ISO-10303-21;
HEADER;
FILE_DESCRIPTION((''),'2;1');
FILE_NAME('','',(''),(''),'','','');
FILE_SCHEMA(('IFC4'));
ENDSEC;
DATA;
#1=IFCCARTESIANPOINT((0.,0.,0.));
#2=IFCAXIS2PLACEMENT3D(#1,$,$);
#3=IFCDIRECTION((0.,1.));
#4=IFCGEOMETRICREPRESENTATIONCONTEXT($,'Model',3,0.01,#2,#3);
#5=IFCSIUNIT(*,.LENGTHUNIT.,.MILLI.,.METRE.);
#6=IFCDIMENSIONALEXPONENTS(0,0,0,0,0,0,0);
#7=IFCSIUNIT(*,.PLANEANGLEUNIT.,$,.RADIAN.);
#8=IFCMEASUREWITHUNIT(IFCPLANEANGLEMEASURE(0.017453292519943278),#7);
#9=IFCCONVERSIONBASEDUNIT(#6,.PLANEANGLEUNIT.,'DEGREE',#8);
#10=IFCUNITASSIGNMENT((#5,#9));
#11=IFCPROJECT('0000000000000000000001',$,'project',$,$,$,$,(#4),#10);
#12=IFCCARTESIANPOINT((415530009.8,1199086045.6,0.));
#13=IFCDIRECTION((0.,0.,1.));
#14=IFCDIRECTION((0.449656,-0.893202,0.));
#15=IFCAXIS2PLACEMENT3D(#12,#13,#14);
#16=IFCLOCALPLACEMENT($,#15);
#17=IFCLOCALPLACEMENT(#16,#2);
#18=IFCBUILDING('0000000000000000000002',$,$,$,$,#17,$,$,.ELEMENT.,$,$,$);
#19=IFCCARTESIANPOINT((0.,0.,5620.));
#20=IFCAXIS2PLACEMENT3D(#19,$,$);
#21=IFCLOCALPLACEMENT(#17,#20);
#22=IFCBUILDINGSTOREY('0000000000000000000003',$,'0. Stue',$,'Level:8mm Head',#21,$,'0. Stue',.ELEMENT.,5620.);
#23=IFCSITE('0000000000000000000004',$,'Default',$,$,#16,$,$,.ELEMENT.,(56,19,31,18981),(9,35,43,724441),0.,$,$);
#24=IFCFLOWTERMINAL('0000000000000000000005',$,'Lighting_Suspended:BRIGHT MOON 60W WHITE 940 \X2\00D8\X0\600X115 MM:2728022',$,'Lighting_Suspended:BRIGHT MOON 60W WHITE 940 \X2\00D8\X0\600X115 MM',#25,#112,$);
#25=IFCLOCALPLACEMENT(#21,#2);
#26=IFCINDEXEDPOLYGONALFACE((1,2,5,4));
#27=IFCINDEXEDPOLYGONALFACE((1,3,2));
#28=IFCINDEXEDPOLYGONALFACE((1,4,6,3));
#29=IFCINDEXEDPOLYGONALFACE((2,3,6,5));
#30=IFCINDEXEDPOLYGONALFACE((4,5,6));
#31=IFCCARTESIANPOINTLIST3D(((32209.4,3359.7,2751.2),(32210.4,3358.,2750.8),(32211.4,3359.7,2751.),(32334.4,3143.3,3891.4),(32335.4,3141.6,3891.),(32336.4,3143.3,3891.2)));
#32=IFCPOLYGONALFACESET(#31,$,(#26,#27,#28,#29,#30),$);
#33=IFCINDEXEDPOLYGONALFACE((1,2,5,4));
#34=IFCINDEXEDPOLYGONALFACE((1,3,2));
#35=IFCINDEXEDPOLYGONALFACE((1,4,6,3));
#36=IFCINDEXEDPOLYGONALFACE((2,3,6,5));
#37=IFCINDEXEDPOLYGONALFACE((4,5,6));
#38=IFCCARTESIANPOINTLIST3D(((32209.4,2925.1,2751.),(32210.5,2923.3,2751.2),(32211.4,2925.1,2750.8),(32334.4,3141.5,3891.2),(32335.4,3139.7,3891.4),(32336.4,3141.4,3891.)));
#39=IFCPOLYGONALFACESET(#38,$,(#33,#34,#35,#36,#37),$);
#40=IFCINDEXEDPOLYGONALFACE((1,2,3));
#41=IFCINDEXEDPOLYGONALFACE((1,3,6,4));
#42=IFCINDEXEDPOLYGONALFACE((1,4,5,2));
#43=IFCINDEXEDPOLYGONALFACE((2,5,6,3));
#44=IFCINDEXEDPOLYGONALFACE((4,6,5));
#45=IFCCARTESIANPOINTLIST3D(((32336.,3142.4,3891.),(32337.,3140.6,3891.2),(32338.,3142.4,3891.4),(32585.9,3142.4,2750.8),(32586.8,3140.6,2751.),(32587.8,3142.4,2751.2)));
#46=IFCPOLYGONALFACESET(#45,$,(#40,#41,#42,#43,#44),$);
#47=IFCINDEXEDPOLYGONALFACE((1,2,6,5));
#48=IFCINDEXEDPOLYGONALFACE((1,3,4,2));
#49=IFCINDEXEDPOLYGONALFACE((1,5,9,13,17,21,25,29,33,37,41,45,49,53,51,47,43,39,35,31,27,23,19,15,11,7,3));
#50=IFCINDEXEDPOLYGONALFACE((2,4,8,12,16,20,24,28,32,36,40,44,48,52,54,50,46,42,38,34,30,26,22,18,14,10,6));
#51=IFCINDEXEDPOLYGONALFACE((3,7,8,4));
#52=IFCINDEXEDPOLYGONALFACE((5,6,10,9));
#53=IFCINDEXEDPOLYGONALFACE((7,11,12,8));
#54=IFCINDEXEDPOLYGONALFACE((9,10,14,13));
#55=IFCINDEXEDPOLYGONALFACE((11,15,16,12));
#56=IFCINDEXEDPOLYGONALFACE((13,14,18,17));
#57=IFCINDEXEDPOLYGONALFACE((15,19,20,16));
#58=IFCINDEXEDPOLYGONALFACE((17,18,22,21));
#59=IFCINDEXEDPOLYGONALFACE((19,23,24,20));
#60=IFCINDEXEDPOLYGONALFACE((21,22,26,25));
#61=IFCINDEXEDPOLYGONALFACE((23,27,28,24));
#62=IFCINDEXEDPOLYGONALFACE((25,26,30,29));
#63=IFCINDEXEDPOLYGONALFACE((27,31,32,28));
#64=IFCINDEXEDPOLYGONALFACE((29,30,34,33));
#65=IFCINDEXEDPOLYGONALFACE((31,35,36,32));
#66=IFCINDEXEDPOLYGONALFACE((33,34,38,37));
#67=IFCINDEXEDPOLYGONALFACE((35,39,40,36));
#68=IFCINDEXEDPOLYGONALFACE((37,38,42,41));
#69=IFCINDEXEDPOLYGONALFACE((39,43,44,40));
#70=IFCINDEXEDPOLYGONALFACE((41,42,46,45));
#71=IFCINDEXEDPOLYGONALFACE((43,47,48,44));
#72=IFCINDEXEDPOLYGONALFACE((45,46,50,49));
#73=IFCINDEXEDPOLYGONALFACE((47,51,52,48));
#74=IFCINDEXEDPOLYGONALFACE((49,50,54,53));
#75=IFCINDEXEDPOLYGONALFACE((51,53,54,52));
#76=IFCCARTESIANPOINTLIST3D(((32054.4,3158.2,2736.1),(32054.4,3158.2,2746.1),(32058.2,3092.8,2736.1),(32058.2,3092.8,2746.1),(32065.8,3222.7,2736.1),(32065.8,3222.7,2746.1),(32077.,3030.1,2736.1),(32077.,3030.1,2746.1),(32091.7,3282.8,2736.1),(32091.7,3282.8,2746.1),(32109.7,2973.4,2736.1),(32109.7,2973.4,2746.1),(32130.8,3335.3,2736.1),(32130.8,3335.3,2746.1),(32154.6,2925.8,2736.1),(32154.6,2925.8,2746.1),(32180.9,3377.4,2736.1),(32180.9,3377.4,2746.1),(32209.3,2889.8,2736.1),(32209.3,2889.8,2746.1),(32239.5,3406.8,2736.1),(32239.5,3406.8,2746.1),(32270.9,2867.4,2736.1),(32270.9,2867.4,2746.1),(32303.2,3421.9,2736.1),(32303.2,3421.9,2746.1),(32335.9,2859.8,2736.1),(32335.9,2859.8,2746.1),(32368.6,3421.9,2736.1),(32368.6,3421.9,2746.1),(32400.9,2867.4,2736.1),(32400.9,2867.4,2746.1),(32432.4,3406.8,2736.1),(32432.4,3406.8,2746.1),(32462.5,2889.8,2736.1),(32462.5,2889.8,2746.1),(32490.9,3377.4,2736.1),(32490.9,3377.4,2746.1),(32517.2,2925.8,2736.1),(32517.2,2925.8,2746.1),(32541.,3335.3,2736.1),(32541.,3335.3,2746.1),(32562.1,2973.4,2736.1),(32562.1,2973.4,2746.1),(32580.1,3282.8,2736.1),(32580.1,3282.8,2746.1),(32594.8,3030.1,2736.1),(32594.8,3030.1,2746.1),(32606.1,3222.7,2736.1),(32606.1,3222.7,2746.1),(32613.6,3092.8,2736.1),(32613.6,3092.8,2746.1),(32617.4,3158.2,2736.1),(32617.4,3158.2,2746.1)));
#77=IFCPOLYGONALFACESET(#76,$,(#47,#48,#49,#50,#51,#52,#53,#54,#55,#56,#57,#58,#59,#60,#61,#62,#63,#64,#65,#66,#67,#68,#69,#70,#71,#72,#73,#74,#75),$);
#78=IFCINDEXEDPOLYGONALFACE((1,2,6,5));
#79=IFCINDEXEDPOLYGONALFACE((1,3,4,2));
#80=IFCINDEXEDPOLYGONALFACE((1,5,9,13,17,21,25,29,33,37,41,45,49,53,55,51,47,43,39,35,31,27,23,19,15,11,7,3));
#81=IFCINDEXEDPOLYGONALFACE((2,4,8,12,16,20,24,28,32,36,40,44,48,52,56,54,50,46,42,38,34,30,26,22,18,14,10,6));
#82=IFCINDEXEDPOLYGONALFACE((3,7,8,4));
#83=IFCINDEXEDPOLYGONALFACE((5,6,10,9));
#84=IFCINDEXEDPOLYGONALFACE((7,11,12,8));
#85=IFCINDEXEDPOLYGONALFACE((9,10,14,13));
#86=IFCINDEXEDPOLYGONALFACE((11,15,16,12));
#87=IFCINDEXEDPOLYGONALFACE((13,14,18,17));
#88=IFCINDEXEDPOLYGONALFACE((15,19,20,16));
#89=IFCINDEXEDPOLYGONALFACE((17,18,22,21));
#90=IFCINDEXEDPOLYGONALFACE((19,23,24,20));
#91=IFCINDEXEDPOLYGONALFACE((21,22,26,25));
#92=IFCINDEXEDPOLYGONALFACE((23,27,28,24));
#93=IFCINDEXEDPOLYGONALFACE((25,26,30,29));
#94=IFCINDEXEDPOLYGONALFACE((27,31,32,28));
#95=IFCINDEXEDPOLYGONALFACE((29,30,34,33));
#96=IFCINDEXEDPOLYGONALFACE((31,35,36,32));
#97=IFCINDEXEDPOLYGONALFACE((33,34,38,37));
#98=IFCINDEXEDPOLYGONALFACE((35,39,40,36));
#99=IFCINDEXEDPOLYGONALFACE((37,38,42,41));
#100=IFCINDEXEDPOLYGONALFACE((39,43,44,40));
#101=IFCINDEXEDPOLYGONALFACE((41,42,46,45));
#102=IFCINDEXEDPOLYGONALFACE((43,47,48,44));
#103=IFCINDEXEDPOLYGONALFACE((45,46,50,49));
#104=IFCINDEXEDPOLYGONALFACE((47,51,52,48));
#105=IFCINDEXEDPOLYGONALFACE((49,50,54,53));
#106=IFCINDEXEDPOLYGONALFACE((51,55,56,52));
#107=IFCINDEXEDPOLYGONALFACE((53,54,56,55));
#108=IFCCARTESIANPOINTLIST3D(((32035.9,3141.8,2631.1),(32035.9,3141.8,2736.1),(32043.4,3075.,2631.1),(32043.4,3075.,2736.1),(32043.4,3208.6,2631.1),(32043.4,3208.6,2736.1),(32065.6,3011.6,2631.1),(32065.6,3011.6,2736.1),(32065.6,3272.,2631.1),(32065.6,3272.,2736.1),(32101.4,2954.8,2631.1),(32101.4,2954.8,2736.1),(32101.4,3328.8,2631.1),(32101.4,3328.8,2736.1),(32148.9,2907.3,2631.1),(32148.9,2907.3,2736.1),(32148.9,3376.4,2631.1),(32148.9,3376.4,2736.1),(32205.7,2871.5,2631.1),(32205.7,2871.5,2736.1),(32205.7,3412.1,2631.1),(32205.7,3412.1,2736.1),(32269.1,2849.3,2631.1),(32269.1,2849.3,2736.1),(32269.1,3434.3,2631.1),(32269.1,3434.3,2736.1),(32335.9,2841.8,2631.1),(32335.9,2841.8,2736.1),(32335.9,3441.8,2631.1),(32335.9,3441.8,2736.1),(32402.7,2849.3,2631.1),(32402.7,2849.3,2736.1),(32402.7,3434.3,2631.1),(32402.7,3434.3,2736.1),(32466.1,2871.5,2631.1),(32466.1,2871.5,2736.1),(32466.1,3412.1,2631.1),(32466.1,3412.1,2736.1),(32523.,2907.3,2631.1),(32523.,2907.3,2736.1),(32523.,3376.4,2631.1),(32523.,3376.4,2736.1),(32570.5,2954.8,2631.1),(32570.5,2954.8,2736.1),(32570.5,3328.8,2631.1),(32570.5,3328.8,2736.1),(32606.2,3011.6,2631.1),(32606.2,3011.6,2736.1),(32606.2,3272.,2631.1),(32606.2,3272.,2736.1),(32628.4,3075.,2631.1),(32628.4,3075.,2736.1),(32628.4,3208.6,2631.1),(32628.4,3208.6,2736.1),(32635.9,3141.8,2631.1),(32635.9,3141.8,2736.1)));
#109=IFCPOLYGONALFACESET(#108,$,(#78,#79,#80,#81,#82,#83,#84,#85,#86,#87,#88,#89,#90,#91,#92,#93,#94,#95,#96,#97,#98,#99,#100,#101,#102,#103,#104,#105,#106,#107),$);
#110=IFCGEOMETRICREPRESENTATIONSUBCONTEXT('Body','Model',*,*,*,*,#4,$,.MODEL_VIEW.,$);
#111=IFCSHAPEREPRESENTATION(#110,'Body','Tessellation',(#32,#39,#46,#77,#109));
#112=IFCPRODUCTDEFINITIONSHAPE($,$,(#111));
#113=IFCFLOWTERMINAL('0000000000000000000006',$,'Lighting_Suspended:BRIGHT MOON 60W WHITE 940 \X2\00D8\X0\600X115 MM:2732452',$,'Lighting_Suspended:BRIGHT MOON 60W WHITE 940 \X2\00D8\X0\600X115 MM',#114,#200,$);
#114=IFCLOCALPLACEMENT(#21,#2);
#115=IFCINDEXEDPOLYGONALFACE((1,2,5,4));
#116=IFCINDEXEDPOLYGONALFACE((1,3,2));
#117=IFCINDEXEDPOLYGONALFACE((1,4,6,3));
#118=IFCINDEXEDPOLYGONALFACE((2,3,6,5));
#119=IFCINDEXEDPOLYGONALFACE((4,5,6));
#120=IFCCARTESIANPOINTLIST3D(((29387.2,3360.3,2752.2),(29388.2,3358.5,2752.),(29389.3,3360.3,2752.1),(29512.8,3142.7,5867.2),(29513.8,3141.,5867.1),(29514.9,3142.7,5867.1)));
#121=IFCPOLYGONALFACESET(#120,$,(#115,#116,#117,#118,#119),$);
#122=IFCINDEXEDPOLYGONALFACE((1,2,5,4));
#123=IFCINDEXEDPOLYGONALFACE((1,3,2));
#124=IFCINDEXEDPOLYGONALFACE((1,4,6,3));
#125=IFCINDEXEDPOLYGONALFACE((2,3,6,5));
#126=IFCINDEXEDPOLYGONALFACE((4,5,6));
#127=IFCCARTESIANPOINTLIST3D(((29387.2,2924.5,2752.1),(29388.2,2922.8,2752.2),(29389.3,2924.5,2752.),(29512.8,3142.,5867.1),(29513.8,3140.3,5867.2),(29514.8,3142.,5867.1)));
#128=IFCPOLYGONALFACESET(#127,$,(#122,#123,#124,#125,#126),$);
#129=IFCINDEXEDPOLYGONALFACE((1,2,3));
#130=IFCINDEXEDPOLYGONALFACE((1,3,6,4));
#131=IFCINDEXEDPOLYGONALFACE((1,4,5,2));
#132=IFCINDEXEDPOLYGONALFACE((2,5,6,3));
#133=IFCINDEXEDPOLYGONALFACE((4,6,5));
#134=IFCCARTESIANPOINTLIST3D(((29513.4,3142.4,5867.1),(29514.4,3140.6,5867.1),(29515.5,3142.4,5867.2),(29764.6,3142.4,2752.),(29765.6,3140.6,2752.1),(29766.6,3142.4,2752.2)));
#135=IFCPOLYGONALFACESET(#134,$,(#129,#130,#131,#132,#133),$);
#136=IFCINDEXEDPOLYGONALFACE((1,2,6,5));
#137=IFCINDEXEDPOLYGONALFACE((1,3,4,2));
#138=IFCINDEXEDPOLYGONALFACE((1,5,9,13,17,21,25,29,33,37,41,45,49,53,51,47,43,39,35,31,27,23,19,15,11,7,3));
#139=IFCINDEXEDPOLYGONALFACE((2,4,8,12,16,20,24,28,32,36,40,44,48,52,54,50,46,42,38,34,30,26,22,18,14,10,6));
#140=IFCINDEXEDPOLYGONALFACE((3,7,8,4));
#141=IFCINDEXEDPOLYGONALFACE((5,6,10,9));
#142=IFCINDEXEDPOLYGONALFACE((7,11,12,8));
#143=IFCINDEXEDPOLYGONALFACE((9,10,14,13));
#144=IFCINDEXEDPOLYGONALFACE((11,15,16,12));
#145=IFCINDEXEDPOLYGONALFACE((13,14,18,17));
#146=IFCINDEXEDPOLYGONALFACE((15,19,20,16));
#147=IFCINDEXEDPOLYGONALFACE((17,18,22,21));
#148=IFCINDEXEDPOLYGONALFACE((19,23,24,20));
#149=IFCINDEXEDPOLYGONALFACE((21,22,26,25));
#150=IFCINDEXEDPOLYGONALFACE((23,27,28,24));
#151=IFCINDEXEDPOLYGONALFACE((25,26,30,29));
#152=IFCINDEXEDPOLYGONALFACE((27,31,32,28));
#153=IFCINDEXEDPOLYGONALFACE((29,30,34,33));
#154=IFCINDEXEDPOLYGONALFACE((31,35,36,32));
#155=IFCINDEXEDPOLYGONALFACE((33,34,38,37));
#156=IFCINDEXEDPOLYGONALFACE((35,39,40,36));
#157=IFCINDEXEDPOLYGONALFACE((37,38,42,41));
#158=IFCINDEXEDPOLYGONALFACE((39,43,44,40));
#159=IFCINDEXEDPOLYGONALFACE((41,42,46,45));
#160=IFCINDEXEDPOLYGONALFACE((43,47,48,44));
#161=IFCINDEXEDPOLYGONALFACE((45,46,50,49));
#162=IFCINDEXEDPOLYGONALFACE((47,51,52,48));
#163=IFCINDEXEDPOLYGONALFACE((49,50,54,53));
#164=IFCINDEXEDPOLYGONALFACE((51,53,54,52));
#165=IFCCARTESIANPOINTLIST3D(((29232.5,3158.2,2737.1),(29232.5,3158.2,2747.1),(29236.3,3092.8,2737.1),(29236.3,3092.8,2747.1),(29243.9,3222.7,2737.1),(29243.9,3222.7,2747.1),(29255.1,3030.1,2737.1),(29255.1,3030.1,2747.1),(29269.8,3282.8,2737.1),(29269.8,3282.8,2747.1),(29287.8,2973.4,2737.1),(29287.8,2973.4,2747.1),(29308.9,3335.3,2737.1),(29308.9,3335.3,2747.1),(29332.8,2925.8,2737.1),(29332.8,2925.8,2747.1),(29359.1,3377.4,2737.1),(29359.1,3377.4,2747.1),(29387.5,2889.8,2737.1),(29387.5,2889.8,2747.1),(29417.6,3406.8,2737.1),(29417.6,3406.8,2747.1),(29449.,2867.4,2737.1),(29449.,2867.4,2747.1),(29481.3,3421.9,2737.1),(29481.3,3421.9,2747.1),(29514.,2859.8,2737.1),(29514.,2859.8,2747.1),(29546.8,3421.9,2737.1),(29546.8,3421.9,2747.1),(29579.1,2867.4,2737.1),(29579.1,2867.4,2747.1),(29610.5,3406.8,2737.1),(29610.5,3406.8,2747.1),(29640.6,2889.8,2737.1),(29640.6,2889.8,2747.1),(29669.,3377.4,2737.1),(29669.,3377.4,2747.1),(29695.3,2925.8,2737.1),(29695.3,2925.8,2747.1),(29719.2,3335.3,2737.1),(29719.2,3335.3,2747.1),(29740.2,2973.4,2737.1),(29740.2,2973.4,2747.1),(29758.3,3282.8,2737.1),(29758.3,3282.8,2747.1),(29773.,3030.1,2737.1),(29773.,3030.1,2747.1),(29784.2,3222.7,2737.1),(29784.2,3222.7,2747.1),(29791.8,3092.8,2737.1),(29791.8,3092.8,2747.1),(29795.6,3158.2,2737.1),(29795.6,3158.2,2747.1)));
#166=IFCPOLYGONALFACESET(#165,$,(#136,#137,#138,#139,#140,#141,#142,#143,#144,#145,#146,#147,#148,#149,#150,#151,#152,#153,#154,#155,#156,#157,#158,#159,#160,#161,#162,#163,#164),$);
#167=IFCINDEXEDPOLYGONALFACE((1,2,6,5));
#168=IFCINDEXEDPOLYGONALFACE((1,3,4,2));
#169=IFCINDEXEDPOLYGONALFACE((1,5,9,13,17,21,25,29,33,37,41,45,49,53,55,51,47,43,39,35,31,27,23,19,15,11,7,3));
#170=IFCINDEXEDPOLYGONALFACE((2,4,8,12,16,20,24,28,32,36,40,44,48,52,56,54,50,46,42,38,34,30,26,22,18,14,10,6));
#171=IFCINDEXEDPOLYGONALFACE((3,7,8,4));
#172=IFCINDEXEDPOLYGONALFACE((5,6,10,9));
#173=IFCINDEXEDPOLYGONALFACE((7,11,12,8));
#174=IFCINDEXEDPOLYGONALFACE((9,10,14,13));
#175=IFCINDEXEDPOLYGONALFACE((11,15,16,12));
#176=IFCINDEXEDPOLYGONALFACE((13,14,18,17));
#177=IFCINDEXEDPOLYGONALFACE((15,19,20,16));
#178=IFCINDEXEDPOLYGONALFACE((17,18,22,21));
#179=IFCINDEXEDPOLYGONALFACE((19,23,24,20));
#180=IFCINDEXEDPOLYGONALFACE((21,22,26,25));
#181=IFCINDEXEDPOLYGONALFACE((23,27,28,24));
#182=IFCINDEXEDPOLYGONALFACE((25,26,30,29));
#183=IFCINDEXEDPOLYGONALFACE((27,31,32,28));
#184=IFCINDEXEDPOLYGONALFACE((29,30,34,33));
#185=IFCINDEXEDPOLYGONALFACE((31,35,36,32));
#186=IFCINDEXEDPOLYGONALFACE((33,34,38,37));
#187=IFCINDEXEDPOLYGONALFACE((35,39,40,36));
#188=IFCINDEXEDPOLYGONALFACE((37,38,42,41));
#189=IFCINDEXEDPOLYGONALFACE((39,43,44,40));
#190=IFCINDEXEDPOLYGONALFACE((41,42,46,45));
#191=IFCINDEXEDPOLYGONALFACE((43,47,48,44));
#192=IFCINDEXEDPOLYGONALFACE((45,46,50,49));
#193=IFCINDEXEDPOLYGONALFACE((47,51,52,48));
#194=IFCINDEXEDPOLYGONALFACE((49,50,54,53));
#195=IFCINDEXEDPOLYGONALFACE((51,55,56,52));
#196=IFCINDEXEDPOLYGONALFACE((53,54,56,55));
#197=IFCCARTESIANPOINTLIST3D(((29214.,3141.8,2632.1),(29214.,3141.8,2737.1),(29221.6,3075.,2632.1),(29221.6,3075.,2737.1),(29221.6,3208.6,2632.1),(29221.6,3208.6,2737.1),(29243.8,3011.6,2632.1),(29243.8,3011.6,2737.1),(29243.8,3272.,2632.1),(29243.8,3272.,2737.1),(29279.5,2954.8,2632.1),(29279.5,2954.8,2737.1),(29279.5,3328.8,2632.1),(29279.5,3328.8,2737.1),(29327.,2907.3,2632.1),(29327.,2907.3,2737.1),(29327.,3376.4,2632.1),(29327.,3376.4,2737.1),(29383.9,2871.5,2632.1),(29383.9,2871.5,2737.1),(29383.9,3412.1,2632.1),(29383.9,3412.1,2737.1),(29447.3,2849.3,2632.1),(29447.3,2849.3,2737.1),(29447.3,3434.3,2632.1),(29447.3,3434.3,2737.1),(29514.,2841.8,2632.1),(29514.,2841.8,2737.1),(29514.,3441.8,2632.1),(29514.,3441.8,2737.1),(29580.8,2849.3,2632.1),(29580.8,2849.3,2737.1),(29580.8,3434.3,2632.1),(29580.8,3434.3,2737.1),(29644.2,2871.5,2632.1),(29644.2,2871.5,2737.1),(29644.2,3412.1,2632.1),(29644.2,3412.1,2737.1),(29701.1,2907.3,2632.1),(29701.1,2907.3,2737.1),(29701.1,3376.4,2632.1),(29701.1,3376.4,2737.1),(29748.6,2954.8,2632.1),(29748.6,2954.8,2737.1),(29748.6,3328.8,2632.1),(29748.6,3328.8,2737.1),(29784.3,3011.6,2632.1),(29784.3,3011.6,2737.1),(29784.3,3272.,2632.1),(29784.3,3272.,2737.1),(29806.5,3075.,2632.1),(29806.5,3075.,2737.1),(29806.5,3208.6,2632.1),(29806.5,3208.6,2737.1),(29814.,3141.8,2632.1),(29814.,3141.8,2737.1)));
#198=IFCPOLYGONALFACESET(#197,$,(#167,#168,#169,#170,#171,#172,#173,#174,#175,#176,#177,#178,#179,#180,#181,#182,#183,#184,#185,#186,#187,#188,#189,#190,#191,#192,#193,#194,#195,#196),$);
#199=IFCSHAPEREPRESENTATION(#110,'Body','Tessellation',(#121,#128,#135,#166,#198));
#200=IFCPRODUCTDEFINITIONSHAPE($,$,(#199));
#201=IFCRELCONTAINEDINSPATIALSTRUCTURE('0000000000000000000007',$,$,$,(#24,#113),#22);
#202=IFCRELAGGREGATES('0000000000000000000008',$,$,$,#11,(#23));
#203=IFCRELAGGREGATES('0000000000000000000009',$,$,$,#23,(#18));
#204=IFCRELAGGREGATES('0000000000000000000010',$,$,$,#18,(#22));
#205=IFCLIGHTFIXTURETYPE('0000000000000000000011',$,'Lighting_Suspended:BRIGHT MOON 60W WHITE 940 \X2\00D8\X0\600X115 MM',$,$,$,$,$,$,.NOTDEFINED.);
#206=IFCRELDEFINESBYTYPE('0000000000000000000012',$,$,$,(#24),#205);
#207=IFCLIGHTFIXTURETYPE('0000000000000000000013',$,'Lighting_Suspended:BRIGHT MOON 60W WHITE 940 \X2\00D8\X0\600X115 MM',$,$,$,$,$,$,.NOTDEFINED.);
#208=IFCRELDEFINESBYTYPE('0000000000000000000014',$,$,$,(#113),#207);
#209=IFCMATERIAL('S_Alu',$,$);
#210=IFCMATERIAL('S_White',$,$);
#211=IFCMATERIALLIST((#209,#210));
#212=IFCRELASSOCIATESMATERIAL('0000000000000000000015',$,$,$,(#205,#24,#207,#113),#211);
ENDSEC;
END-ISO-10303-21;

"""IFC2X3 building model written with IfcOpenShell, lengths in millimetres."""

from ifc_helpers import new_model, entity, si_unit, converted_unit, direction, frame, frame_2d, origin, place, context, subcontext, project, spatial, polyline, circle, outline, extrude, source, transform, mapped, material, material_list, type_object, type_shapes, element, save


model = new_model("IFC2X3")

# Units and contexts
model_context = context("Model", 3, precision=0.01, world=origin(), true_north=direction((0.0, 1.0)))
body_context = subcontext(model_context, "Body", "Model", "MODEL_VIEW")
ifc_project = project(units=[si_unit("LENGTHUNIT", "METRE", prefix="MILLI"), converted_unit("PLANEANGLEUNIT", "DEGREE", entity("IfcPlaneAngleMeasure", 0.017453292519943278), si_unit("PLANEANGLEUNIT", "RADIAN"), dimensions=[0, 0, 0, 0, 0, 0, 0])], contexts=[model_context])

# Site, building, storey
site_placement = place(None, frame((415530009.8, 1199086045.6, 0.0), z_axis=(0.0, 0.0, 1.0), x_axis=(0.449656, -0.893202, 0.0)))
site = spatial("IfcSite", under=ifc_project, at=site_placement, Name="Default", CompositionType="ELEMENT", RefLatitude=(56, 19, 31, 18981), RefLongitude=(9, 35, 43, 724441), RefElevation=0.0)
building_placement = place(site_placement, origin())
building = spatial("IfcBuilding", under=site, at=building_placement, CompositionType="ELEMENT")
storey_placement = place(building_placement, frame((0.0, 0.0, 5620.0)))
storey = spatial("IfcBuildingStorey", under=building, at=storey_placement, Name="0. Stue", ObjectType="Level:8mm Head", LongName="0. Stue", CompositionType="ELEMENT", Elevation=5620.0)

# Flow terminals
ifc_material_1 = material(Name="S_Alu")
ifc_material_2 = material(Name="S_White")
ifc_material_list_1 = material_list([ifc_material_1, ifc_material_2])
light_fixture_type_1 = type_object("IfcLightFixtureType", Name="Lighting_Suspended:BRIGHT MOON 60W WHITE 940 Ø600X115 MM", PredefinedType="NOTDEFINED", material=ifc_material_list_1)
shared_shape_1 = source(origin(), body_context, "Body", "SweptSolid", [
    extrude(outline(polyline([(-1.0, -0.6), (1.0, -0.6), (0.0, 1.2), (-1.0, -0.6)])), frame((-217.3, -125.5, -1145.1), z_axis=(0.185374, 0.107026, 0.976822), x_axis=(-0.855989, 0.505794, 0.107026)), (0.0, 0.0, 1.0), 1167.3),
    extrude(outline(polyline([(-1.0, -0.6), (1.0, -0.6), (0.0, 1.2), (-1.0, -0.6)])), frame((217.3, -125.5, -1145.1), z_axis=(-0.185374, 0.107026, 0.976822), x_axis=(-0.010036, -0.994206, 0.107026)), (0.0, 0.0, 1.0), 1167.3),
    extrude(outline(polyline([(-1.0, -0.6), (1.0, -0.6), (0.0, 1.2), (-1.0, -0.6)])), frame((0.0, 250.9, -1145.1), z_axis=(0.0, -0.214052, 0.976822), x_axis=(0.866025, 0.488411, 0.107026)), (0.0, 0.0, 1.0), 1167.3),
    extrude(circle(Radius=282.0, at=frame_2d((0.0, 0.0), x_axis=(1.0, 0.0))), frame((0.0, 0.0, -1160.0)), (0.0, 0.0, 1.0), 10.0),
    extrude(circle(Radius=300.0, at=frame_2d((0.0, 0.0), x_axis=(1.0, 0.0))), frame((0.0, 0.0, -1265.0)), (0.0, 0.0, 1.0), 105.0),
])
type_shapes(light_fixture_type_1, [shared_shape_1])
flow_terminal_1_placement = place(storey_placement, frame((32335.9, 3141.8, 3896.1), z_axis=(0.0, 0.0, 1.0), x_axis=(0.0, -1.0, 0.0)))
element("IfcFlowTerminal", 1, at=flow_terminal_1_placement, inside=storey, type_object=light_fixture_type_1, material=ifc_material_list_1, Name="Lighting_Suspended:BRIGHT MOON 60W WHITE 940 Ø600X115 MM:2728022", ObjectType="Lighting_Suspended:BRIGHT MOON 60W WHITE 940 Ø600X115 MM", context=body_context, shape_type="MappedRepresentation", body=[
    mapped(shared_shape_1, transform((0.0, 0.0, 0.0), scale=1.0)),
])
light_fixture_type_2 = type_object("IfcLightFixtureType", Name="Lighting_Suspended:BRIGHT MOON 60W WHITE 940 Ø600X115 MM", PredefinedType="NOTDEFINED", material=ifc_material_list_1)
shared_shape_2 = source(origin(), body_context, "Body", "SweptSolid", [
    extrude(outline(polyline([(-1.0, -0.6), (1.0, -0.6), (0.0, 1.2), (-1.0, -0.6)])), frame((-217.9, -125.8, -3120.0), z_axis=(0.06961, 0.04019, 0.996764), x_axis=(-0.864624, 0.500809, 0.04019)), (0.0, 0.0, 1.0), 3125.1),
    extrude(outline(polyline([(-1.0, -0.6), (1.0, -0.6), (0.0, 1.2), (-1.0, -0.6)])), frame((217.9, -125.8, -3120.0), z_axis=(-0.06961, 0.04019, 0.996764), x_axis=(-0.001401, -0.999191, 0.04019)), (0.0, 0.0, 1.0), 3125.1),
    extrude(outline(polyline([(-1.0, -0.6), (1.0, -0.6), (0.0, 1.2), (-1.0, -0.6)])), frame((0.0, 251.6, -3120.0), z_axis=(0.0, -0.080379, 0.996764), x_axis=(0.866025, 0.498382, 0.04019)), (0.0, 0.0, 1.0), 3125.1),
    extrude(circle(Radius=282.0, at=frame_2d((0.0, 0.0), x_axis=(1.0, 0.0))), frame((0.0, 0.0, -3135.0)), (0.0, 0.0, 1.0), 10.0),
    extrude(circle(Radius=300.0, at=frame_2d((0.0, 0.0), x_axis=(1.0, 0.0))), frame((0.0, 0.0, -3240.0)), (0.0, 0.0, 1.0), 105.0),
])
type_shapes(light_fixture_type_2, [shared_shape_2])
flow_terminal_2_placement = place(storey_placement, frame((29514.0, 3141.8, 5872.1), z_axis=(0.0, 0.0, 1.0), x_axis=(0.0, -1.0, 0.0)))
element("IfcFlowTerminal", 2, at=flow_terminal_2_placement, inside=storey, type_object=light_fixture_type_2, material=ifc_material_list_1, Name="Lighting_Suspended:BRIGHT MOON 60W WHITE 940 Ø600X115 MM:2732452", ObjectType="Lighting_Suspended:BRIGHT MOON 60W WHITE 940 Ø600X115 MM", context=body_context, shape_type="MappedRepresentation", body=[
    mapped(shared_shape_2, transform((0.0, 0.0, 0.0), scale=1.0)),
])

save(model, "model.ifc")
